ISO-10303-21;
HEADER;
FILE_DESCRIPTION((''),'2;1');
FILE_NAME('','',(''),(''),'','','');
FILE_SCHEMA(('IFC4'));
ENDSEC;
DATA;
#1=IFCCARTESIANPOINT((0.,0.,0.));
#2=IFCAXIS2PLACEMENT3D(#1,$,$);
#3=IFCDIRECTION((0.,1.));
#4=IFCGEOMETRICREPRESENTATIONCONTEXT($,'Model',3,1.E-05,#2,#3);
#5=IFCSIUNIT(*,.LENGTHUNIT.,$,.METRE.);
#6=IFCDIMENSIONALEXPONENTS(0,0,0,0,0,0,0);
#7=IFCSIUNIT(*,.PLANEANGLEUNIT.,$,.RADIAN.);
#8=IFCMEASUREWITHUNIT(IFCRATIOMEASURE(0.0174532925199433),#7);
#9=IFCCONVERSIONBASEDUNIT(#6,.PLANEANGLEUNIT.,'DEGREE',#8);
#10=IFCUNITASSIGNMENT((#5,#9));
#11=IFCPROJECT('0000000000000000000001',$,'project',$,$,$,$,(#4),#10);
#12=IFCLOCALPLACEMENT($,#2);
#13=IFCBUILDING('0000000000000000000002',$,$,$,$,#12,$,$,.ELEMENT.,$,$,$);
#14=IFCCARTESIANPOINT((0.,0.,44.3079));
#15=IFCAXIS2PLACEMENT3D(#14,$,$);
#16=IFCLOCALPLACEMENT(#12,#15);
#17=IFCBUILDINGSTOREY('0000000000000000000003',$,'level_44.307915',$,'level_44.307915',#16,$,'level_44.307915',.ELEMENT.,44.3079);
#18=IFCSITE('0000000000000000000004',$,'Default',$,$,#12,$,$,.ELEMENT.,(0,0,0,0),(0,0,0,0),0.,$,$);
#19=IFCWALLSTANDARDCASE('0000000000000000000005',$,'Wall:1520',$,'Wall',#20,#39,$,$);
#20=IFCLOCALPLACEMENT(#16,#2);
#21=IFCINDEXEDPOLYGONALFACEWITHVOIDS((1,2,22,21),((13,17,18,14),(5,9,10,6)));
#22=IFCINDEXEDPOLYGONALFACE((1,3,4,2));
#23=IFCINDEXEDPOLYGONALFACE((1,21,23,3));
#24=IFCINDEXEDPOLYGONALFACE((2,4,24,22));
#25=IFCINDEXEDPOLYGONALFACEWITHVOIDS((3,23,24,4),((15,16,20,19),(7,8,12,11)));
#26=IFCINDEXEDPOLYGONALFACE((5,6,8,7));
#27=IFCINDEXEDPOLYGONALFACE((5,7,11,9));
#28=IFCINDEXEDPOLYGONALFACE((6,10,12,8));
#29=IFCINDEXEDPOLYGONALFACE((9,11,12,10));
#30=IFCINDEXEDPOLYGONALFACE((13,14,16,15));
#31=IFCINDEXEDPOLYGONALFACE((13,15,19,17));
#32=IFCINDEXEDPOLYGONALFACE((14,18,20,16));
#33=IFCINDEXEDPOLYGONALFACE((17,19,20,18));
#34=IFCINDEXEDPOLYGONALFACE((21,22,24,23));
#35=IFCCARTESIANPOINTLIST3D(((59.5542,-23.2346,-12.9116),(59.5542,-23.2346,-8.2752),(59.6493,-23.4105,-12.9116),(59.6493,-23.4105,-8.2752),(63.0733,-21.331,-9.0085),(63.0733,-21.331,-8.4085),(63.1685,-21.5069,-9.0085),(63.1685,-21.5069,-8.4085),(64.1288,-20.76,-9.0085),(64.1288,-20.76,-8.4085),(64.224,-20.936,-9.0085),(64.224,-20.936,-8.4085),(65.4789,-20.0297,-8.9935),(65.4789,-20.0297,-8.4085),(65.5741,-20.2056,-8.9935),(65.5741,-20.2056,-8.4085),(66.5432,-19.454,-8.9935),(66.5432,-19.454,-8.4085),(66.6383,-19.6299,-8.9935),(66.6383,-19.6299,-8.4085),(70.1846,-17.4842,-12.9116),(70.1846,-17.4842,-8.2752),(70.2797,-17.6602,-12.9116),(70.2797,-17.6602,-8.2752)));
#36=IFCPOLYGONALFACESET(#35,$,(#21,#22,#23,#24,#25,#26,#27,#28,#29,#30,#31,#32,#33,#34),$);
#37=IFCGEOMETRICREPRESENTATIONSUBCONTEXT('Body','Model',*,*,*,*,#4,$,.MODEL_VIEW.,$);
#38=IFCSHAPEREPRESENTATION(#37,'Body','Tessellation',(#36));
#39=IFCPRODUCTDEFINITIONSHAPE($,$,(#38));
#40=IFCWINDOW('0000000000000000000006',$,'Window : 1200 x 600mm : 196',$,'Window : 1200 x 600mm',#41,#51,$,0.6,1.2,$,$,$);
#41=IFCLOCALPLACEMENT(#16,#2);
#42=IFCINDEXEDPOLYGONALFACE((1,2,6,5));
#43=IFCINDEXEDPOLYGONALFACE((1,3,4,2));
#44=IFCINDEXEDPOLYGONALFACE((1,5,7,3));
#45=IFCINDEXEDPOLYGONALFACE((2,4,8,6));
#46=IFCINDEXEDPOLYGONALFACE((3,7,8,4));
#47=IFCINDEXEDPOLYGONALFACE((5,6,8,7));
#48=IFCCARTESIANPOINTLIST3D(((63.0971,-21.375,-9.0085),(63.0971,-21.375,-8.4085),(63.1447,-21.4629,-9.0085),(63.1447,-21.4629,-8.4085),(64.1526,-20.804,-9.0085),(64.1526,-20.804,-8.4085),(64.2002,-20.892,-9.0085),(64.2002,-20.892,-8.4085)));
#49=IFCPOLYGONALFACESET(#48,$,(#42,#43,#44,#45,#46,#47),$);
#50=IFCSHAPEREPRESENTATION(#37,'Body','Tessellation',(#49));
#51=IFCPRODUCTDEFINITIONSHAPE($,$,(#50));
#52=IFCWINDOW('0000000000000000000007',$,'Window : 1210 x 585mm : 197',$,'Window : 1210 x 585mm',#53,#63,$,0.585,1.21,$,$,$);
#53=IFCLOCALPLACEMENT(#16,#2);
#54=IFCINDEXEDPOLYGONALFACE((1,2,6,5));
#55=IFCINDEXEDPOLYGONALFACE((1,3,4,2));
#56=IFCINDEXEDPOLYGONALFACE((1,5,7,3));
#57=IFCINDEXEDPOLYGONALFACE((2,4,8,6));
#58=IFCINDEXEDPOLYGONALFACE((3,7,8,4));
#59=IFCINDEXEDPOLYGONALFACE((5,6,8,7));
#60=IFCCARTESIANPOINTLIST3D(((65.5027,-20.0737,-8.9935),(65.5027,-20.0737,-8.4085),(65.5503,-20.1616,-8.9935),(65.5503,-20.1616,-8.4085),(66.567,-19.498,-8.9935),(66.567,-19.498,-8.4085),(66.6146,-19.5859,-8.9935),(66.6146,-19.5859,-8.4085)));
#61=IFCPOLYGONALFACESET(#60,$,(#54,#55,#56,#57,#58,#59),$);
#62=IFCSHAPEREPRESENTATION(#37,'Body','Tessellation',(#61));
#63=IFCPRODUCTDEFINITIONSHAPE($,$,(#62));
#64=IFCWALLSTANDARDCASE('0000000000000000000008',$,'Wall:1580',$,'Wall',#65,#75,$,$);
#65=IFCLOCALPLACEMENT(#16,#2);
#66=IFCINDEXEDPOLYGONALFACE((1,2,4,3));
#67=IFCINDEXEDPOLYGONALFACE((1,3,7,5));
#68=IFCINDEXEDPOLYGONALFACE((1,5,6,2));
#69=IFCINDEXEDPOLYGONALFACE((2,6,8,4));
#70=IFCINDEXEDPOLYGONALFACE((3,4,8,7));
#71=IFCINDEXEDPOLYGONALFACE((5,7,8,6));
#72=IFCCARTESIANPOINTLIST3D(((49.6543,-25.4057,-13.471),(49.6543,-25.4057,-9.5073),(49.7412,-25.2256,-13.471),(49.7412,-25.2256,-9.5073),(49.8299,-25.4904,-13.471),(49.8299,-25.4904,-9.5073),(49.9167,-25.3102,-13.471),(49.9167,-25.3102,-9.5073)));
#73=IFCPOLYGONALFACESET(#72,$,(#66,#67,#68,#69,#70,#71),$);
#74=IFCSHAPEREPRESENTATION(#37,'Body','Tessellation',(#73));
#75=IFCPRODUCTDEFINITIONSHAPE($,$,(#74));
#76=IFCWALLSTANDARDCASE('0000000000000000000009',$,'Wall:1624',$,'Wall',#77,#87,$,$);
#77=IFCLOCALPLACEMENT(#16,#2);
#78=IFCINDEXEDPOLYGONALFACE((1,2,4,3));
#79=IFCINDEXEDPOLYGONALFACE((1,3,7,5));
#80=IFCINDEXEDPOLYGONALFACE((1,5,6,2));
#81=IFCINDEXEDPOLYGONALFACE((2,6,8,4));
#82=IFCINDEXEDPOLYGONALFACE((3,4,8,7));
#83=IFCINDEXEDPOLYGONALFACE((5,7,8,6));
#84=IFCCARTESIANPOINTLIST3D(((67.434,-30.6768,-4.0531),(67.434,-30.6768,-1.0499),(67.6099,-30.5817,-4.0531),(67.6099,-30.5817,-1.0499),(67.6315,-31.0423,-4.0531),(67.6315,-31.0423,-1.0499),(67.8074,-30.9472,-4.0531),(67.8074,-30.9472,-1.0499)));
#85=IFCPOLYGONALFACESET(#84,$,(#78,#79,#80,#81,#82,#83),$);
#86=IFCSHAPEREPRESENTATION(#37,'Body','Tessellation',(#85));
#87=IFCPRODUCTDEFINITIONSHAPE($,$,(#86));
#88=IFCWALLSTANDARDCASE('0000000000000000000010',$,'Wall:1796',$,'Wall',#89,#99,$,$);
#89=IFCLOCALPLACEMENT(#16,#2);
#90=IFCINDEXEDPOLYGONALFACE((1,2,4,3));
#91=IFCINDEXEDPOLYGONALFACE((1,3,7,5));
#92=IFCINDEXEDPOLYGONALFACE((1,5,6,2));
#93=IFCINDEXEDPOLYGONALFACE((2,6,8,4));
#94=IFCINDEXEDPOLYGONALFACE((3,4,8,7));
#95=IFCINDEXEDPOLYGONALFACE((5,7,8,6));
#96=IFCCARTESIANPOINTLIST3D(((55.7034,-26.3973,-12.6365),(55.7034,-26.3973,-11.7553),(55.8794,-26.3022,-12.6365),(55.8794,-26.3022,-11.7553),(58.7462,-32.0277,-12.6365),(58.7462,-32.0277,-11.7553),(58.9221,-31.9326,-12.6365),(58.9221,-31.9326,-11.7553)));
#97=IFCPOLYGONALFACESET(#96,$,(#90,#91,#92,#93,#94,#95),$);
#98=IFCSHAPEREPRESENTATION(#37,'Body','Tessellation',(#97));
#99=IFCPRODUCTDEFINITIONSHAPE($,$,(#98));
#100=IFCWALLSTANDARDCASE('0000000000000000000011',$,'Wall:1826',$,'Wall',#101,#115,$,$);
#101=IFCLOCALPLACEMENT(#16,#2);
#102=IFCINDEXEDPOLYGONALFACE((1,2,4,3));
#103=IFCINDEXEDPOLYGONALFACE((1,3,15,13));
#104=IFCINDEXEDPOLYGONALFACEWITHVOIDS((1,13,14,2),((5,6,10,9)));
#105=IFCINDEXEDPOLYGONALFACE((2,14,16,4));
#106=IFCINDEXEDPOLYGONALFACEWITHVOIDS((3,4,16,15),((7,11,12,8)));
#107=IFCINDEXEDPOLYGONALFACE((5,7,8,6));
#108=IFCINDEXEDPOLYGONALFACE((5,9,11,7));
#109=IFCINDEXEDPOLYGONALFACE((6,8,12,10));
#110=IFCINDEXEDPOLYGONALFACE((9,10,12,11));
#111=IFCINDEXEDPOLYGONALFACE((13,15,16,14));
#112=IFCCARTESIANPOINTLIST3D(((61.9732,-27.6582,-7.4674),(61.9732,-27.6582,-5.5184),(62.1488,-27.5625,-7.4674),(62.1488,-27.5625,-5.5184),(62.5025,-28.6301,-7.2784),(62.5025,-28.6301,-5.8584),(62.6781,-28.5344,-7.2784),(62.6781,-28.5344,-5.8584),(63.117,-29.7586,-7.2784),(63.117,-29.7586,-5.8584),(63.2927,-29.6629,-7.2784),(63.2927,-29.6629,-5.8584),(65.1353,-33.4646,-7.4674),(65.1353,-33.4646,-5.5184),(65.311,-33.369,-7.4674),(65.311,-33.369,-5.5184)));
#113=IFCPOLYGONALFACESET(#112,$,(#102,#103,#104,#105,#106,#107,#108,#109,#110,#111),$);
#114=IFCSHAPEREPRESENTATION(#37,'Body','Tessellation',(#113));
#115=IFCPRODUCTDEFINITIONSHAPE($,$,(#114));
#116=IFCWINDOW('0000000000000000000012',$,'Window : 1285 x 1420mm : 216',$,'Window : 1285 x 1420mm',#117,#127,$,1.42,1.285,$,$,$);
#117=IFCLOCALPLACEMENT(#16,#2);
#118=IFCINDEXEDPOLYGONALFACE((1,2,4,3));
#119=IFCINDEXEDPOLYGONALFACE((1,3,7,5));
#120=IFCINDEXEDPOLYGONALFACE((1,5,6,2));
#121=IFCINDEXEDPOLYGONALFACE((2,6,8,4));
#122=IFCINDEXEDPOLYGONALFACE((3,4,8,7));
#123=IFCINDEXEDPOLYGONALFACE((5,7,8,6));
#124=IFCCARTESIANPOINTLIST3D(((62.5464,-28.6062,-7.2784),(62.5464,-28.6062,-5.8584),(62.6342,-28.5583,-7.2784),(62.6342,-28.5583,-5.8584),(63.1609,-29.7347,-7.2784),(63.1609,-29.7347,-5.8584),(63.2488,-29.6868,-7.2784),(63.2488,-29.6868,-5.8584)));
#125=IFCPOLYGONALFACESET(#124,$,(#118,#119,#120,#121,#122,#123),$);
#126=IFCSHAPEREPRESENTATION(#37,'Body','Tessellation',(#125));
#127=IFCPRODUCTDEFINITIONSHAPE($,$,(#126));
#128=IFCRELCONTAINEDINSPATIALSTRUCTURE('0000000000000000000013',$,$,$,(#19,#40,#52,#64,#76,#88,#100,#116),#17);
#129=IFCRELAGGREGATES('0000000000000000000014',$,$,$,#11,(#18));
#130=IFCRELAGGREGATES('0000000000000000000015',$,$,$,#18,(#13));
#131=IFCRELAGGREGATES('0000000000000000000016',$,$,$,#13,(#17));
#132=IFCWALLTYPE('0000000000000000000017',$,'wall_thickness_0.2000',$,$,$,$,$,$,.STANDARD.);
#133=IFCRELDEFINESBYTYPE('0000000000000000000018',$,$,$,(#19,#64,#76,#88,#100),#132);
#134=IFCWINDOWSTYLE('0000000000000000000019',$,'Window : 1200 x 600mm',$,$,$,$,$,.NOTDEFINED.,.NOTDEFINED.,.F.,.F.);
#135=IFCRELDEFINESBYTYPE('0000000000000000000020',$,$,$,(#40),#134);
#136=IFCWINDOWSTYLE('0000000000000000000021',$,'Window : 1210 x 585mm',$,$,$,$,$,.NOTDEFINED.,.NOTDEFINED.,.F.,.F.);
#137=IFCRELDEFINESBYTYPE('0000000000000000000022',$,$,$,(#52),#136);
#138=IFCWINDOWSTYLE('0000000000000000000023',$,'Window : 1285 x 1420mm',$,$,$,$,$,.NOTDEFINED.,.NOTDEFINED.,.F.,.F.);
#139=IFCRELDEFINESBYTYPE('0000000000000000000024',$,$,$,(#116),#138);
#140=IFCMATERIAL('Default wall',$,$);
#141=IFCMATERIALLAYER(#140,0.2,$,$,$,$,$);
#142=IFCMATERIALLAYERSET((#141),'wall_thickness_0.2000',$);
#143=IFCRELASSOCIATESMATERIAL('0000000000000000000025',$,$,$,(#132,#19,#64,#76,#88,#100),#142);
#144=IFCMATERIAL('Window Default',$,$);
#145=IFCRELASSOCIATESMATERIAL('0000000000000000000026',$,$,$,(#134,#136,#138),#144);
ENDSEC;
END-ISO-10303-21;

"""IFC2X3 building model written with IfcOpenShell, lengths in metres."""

from ifc_helpers import new_model, entity, si_unit, converted_unit, direction, frame, frame_2d, origin, origin_2d_with_axis, place, context, subcontext, project, spatial, polyline, rectangle, outline, extrude, source, transform, mapped, material, layer, layer_set, layer_usage, type_object, type_shapes, element, fill, save


model = new_model("IFC2X3")

# Units and contexts
model_context = context("Model", 3, precision=1e-05, world=origin(), true_north=direction((0.0, 1.0)))
body_context = subcontext(model_context, "Body", "Model", "MODEL_VIEW")
ifc_project = project(units=[si_unit("LENGTHUNIT", "METRE"), converted_unit("PLANEANGLEUNIT", "DEGREE", entity("IfcRatioMeasure", 0.0174532925199433), si_unit("PLANEANGLEUNIT", "RADIAN"), dimensions=[0, 0, 0, 0, 0, 0, 0])], contexts=[model_context])

# Site, building, storey
placement_1 = place(None, origin())
site = spatial("IfcSite", under=ifc_project, at=placement_1, Name="Default", CompositionType="ELEMENT", RefLatitude=(0, 0, 0, 0), RefLongitude=(0, 0, 0, 0), RefElevation=0.0)
building = spatial("IfcBuilding", under=site, at=placement_1, CompositionType="ELEMENT")
storey_placement = place(placement_1, frame((0.0, 0.0, 44.3079)))
storey = spatial("IfcBuildingStorey", under=building, at=storey_placement, Name="level_44.307915", ObjectType="level_44.307915", LongName="level_44.307915", CompositionType="ELEMENT", Elevation=44.3079)

# Shared definitions
ifc_material_1 = material(Name="Default wall")
ifc_layer = layer(ifc_material_1, 0.2)
ifc_layer_set = layer_set([ifc_layer], Name="wall_thickness_0.2000")
ifc_layer_usage = layer_usage(ifc_layer_set, "AXIS2", "POSITIVE", -0.1)
wall_type = type_object("IfcWallType", Name="wall_thickness_0.2000", PredefinedType="STANDARD", material=ifc_layer_set)

# Shared definitions
ifc_material_2 = material(Name="Window Default")

# Wall, openings, windows
placement_2 = place(placement_1, frame((0.0, 0.0, 31.3963)))
wall_1_placement = place(placement_2, frame((59.6018, -23.3226, 0.0), z_axis=(0.0, 0.0, 1.0), x_axis=(0.87956, 0.475788, 0.0)))
wall_1 = element("IfcWallStandardCase", 1, at=wall_1_placement, inside=storey, type_object=wall_type, material=ifc_layer_usage, Name="Wall:1520", ObjectType="Wall", context=body_context, shape_type="SweptSolid", body=[
    extrude(outline(polyline([(12.086, -0.1), (12.086, 0.1), (0.0, 0.1), (0.0, -0.1), (12.086, -0.1)])), origin(), (0.0, 0.0, 1.0), 4.6364),
])
opening_1_placement = place(wall_1_placement, frame((4.001, -0.1, 3.9031)))
opening_1 = element("IfcOpeningElement", 2, at=opening_1_placement, cuts=wall_1, ObjectType="Opening", context=body_context, shape_type="SweptSolid", body=[
    extrude(rectangle(XDim=1.2, YDim=0.6, at=frame_2d((0.3, 0.6), x_axis=(0.0, 1.0))), frame((0.0, 0.0, 0.0), z_axis=(0.0, 1.0, 0.0), x_axis=(0.0, 0.0, 1.0)), (0.0, 0.0, 1.0), 0.2),
])
opening_2_placement = place(wall_1_placement, frame((6.736, -0.1, 3.9181)))
opening_2 = element("IfcOpeningElement", 3, at=opening_2_placement, cuts=wall_1, ObjectType="Opening", context=body_context, shape_type="SweptSolid", body=[
    extrude(rectangle(XDim=1.21, YDim=0.585, at=frame_2d((0.2925, 0.605), x_axis=(0.0, 1.0))), frame((0.0, 0.0, 0.0), z_axis=(0.0, 1.0, 0.0), x_axis=(0.0, 0.0, 1.0)), (0.0, 0.0, 1.0), 0.2),
])
window_style_1 = type_object("IfcWindowStyle", Name="Window : 1200 x 600mm", ConstructionType="NOTDEFINED", OperationType="NOTDEFINED", ParameterTakesPrecedence=False, Sizeable=False, material=ifc_material_2)
shared_shape_1 = source(origin(), body_context, "Body", "SweptSolid", [
    extrude(rectangle(XDim=0.1, YDim=1.2, at=origin_2d_with_axis()), frame((0.6, 0.1, 0.0), z_axis=(0.0, 0.0, 1.0), x_axis=(0.0, 1.0, 0.0)), (0.0, 0.0, 1.0), 0.6),
])
type_shapes(window_style_1, [shared_shape_1])
window_1_placement = place(opening_1_placement, origin())
window_1 = element("IfcWindow", 4, at=window_1_placement, inside=storey, type_object=window_style_1, Name="Window : 1200 x 600mm : 196", ObjectType="Window : 1200 x 600mm", OverallHeight=0.6, OverallWidth=1.2, context=body_context, shape_type="MappedRepresentation", body=[
    mapped(shared_shape_1, transform((0.0, 0.0, 0.0), scale=1.0)),
])
fill(opening_1, window_1)
window_style_2 = type_object("IfcWindowStyle", Name="Window : 1210 x 585mm", ConstructionType="NOTDEFINED", OperationType="NOTDEFINED", ParameterTakesPrecedence=False, Sizeable=False, material=ifc_material_2)
shared_shape_2 = source(origin(), body_context, "Body", "SweptSolid", [
    extrude(rectangle(XDim=0.1, YDim=1.21, at=origin_2d_with_axis()), frame((0.605, 0.1, 0.0), z_axis=(0.0, 0.0, 1.0), x_axis=(0.0, 1.0, 0.0)), (0.0, 0.0, 1.0), 0.585),
])
type_shapes(window_style_2, [shared_shape_2])
window_2_placement = place(opening_2_placement, origin())
window_2 = element("IfcWindow", 5, at=window_2_placement, inside=storey, type_object=window_style_2, Name="Window : 1210 x 585mm : 197", ObjectType="Window : 1210 x 585mm", OverallHeight=0.585, OverallWidth=1.21, context=body_context, shape_type="MappedRepresentation", body=[
    mapped(shared_shape_2, transform((0.0, 0.0, 0.0), scale=1.0)),
])
fill(opening_2, window_2)

# Walls
placement_3 = place(placement_1, frame((0.0, 0.0, 30.8369)))
wall_2_placement = place(placement_3, frame((49.8733, -25.4003, 0.0), z_axis=(0.0, 0.0, 1.0), x_axis=(-0.900782, 0.434271, 0.0)))
element("IfcWallStandardCase", 6, at=wall_2_placement, inside=storey, type_object=wall_type, material=ifc_layer_usage, Name="Wall:1580", ObjectType="Wall", context=body_context, shape_type="SweptSolid", body=[
    extrude(outline(polyline([(0.1949, -0.1), (0.1949, 0.1), (0.0, 0.1), (0.0, -0.1), (0.1949, -0.1)])), origin(), (0.0, 0.0, 1.0), 3.9637),
])
placement_4 = place(placement_1, frame((0.0, 0.0, 40.2548)))
wall_3_placement = place(placement_4, frame((67.7195, -30.9947, 0.0), z_axis=(0.0, 0.0, 1.0), x_axis=(-0.475468, 0.879733, 0.0)))
element("IfcWallStandardCase", 7, at=wall_3_placement, inside=storey, type_object=wall_type, material=ifc_layer_usage, Name="Wall:1624", ObjectType="Wall", context=body_context, shape_type="SweptSolid", body=[
    extrude(outline(polyline([(0.4154, -0.1), (0.4154, 0.1), (0.0, 0.1), (0.0, -0.1), (0.4154, -0.1)])), origin(), (0.0, 0.0, 1.0), 3.0032),
])
placement_5 = place(placement_1, frame((0.0, 0.0, 31.6714)))
wall_4_placement = place(placement_5, frame((55.7914, -26.3498, 0.0), z_axis=(0.0, 0.0, 1.0), x_axis=(0.475434, -0.879751, 0.0)))
element("IfcWallStandardCase", 8, at=wall_4_placement, inside=storey, type_object=wall_type, material=ifc_layer_usage, Name="Wall:1796", ObjectType="Wall", context=body_context, shape_type="SweptSolid", body=[
    extrude(outline(polyline([(6.4, -0.1), (6.4, 0.1), (0.0, 0.1), (0.0, -0.1), (6.4, -0.1)])), origin(), (0.0, 0.0, 1.0), 0.8812),
])

# Wall, opening, window
placement_6 = place(placement_1, frame((0.0, 0.0, 36.8405)))
wall_5_placement = place(placement_6, frame((62.061, -27.6103, 0.0), z_axis=(0.0, 0.0, 1.0), x_axis=(0.478269, -0.878213, 0.0)))
wall_5 = element("IfcWallStandardCase", 9, at=wall_5_placement, inside=storey, type_object=wall_type, material=ifc_layer_usage, Name="Wall:1826", ObjectType="Wall", context=body_context, shape_type="SweptSolid", body=[
    extrude(outline(polyline([(6.6117, -0.1), (6.6117, 0.1), (0.0, 0.1), (0.0, -0.1), (6.6117, -0.1)])), origin(), (0.0, 0.0, 1.0), 1.949),
])
opening_3_placement = place(wall_5_placement, frame((1.1067, -0.1, 0.189)))
opening_3 = element("IfcOpeningElement", 10, at=opening_3_placement, cuts=wall_5, ObjectType="Opening", context=body_context, shape_type="SweptSolid", body=[
    extrude(rectangle(XDim=1.285, YDim=1.42, at=frame_2d((0.71, 0.6425), x_axis=(0.0, 1.0))), frame((0.0, 0.0, 0.0), z_axis=(0.0, 1.0, 0.0), x_axis=(0.0, 0.0, 1.0)), (0.0, 0.0, 1.0), 0.2),
])
window_style_3 = type_object("IfcWindowStyle", Name="Window : 1285 x 1420mm", ConstructionType="NOTDEFINED", OperationType="NOTDEFINED", ParameterTakesPrecedence=False, Sizeable=False, material=ifc_material_2)
shared_shape_3 = source(origin(), body_context, "Body", "SweptSolid", [
    extrude(rectangle(XDim=0.1, YDim=1.285, at=origin_2d_with_axis()), frame((0.6425, 0.1, 0.0), z_axis=(0.0, 0.0, 1.0), x_axis=(0.0, 1.0, 0.0)), (0.0, 0.0, 1.0), 1.42),
])
type_shapes(window_style_3, [shared_shape_3])
window_3_placement = place(opening_3_placement, origin())
window_3 = element("IfcWindow", 11, at=window_3_placement, inside=storey, type_object=window_style_3, Name="Window : 1285 x 1420mm : 216", ObjectType="Window : 1285 x 1420mm", OverallHeight=1.42, OverallWidth=1.285, context=body_context, shape_type="MappedRepresentation", body=[
    mapped(shared_shape_3, transform((0.0, 0.0, 0.0), scale=1.0)),
])
fill(opening_3, window_3)

save(model, "model.ifc")
